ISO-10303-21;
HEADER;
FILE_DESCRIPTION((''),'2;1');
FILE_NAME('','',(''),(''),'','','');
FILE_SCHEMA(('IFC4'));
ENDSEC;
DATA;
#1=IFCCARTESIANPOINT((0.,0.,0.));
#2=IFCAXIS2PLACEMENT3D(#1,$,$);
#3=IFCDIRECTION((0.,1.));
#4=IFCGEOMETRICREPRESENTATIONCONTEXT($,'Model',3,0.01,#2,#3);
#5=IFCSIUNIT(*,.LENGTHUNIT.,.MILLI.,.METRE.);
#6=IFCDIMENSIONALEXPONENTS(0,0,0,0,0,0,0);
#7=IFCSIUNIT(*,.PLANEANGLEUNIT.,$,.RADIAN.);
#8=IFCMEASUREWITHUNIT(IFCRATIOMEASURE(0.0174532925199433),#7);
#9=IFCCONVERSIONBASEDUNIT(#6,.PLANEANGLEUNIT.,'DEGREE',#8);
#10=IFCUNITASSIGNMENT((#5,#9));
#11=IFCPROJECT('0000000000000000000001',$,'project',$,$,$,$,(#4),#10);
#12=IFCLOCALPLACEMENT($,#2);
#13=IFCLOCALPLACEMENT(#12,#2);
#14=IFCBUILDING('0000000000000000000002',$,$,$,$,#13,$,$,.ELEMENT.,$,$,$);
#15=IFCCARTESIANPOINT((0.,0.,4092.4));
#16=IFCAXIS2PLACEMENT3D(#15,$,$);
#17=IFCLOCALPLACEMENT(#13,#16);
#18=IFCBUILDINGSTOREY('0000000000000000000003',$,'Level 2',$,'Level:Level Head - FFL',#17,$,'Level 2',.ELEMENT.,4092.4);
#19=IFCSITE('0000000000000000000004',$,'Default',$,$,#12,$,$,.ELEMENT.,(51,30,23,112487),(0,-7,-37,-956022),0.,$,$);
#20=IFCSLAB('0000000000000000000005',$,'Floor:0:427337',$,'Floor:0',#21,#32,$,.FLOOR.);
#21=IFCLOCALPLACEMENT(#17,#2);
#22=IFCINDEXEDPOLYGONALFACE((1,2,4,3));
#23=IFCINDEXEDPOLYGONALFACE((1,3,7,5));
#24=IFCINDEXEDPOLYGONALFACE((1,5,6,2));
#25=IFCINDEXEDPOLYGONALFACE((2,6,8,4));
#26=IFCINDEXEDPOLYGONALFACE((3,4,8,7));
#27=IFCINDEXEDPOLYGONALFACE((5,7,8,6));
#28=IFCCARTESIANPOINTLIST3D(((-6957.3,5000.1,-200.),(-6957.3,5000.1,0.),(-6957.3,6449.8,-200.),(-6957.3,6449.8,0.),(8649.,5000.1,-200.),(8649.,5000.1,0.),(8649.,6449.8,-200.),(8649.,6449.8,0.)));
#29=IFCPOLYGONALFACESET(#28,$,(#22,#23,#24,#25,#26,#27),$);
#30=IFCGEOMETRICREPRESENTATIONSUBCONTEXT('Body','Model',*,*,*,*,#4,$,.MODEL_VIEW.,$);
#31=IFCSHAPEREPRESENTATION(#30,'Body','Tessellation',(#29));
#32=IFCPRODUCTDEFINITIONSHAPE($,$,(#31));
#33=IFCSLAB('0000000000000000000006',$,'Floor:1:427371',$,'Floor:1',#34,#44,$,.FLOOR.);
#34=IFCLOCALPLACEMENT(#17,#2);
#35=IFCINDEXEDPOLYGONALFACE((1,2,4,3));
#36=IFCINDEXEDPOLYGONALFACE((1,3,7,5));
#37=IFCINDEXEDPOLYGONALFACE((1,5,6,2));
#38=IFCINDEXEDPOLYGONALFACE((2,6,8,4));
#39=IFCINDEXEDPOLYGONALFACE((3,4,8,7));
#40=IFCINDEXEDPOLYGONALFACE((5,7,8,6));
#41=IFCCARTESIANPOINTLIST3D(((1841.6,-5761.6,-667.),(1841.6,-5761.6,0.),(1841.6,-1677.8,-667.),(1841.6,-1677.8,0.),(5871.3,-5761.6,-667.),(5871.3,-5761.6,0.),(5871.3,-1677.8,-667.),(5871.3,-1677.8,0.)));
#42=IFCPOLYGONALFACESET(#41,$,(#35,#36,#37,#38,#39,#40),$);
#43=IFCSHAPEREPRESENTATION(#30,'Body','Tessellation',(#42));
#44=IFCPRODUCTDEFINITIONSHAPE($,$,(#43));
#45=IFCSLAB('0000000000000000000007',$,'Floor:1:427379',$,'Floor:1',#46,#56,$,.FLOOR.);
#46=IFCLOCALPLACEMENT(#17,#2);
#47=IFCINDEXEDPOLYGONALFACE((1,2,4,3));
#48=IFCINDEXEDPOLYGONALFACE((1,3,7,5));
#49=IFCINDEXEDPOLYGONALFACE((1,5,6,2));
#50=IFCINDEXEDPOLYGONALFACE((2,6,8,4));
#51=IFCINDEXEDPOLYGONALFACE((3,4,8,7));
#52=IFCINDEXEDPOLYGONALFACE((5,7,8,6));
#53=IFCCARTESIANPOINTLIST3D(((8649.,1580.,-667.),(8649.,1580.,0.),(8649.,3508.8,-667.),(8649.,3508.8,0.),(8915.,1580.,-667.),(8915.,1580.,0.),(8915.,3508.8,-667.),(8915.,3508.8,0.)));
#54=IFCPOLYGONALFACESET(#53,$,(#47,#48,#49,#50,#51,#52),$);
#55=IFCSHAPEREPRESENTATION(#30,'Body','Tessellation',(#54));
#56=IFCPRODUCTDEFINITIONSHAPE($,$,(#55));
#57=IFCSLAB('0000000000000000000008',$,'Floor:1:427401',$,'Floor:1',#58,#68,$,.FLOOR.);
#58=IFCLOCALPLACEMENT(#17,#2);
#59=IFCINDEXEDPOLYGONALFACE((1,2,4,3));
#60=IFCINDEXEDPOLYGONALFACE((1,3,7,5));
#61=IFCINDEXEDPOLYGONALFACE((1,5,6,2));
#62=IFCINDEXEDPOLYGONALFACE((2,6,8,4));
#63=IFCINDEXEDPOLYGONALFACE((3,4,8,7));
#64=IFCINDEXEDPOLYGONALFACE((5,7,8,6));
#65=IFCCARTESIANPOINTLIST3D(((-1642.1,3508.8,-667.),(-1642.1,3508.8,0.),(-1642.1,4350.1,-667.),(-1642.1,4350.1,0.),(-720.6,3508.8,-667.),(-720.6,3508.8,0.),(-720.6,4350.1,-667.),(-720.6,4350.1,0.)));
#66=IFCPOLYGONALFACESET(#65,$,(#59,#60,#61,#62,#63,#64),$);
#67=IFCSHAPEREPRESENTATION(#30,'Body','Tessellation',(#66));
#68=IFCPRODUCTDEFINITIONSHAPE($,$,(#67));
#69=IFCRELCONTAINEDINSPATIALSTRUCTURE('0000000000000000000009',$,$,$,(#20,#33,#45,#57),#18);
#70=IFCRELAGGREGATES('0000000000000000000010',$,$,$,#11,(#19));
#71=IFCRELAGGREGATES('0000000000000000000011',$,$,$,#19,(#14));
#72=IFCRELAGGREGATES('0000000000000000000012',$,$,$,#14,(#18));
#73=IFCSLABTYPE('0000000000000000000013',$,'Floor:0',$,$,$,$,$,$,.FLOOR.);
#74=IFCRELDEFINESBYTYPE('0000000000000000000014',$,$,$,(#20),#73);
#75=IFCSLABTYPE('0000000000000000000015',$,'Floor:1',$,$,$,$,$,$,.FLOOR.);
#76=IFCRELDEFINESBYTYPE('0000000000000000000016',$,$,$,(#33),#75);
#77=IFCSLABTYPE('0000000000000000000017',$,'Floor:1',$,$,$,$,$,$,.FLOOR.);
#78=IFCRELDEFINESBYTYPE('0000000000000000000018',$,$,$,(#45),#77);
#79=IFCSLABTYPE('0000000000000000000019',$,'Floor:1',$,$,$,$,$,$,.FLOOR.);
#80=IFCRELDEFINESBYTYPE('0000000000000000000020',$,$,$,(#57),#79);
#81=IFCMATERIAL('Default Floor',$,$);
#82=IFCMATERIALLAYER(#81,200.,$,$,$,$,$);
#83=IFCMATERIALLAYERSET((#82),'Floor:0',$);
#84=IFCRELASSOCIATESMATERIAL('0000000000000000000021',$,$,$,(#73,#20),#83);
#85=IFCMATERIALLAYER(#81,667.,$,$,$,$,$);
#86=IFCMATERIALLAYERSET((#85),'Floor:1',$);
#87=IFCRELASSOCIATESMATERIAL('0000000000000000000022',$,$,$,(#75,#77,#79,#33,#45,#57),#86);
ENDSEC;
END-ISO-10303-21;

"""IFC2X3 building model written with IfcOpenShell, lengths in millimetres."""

from ifc_helpers import new_model, entity, si_unit, converted_unit, direction, frame, frame_2d, origin, origin_2d_with_axis, place, context, subcontext, project, spatial, rectangle, extrude, material, layer, layer_set, layer_usage, type_object, element, save


model = new_model("IFC2X3")

# Units and contexts
model_context = context("Model", 3, precision=0.01, world=origin(), true_north=direction((0.0, 1.0)))
body_context = subcontext(model_context, "Body", "Model", "MODEL_VIEW")
ifc_project = project(units=[si_unit("LENGTHUNIT", "METRE", prefix="MILLI"), converted_unit("PLANEANGLEUNIT", "DEGREE", entity("IfcRatioMeasure", 0.0174532925199433), si_unit("PLANEANGLEUNIT", "RADIAN"), dimensions=[0, 0, 0, 0, 0, 0, 0])], contexts=[model_context])

# Site, building, storey
site_placement = place(None, origin())
site = spatial("IfcSite", under=ifc_project, at=site_placement, Name="Default", CompositionType="ELEMENT", RefLatitude=(51, 30, 23, 112487), RefLongitude=(0, -7, -37, -956022), RefElevation=0.0)
building_placement = place(site_placement, origin())
building = spatial("IfcBuilding", under=site, at=building_placement, CompositionType="ELEMENT")
storey_placement = place(building_placement, frame((0.0, 0.0, 4092.4)))
storey = spatial("IfcBuildingStorey", under=building, at=storey_placement, Name="Level 2", ObjectType="Level:Level Head - FFL", LongName="Level 2", CompositionType="ELEMENT", Elevation=4092.4)

# Slabs
ifc_material = material(Name="Default Floor")
ifc_layer_1 = layer(ifc_material, 200.0)
ifc_layer_set_1 = layer_set([ifc_layer_1], Name="Floor:0")
ifc_layer_usage_1 = layer_usage(ifc_layer_set_1, "AXIS3", "POSITIVE", 0.0)
slab_type_1 = type_object("IfcSlabType", Name="Floor:0", PredefinedType="FLOOR", material=ifc_layer_set_1)
slab_1_placement = place(storey_placement, origin())
element("IfcSlab", 1, at=slab_1_placement, inside=storey, type_object=slab_type_1, material=ifc_layer_usage_1, Name="Floor:0:427337", ObjectType="Floor:0", PredefinedType="FLOOR", context=body_context, shape_type="SweptSolid", body=[
    extrude(rectangle(XDim=1449.7, YDim=15606.3, at=frame_2d((0.0, 0.0), x_axis=(1.0, 0.0))), frame((845.8, 5725.0, 0.0), z_axis=(0.0, 0.0, -1.0), x_axis=(0.0, 1.0, 0.0)), (0.0, 0.0, 1.0), 200.0),
])
ifc_layer_2 = layer(ifc_material, 667.0)
ifc_layer_set_2 = layer_set([ifc_layer_2], Name="Floor:1")
ifc_layer_usage_2 = layer_usage(ifc_layer_set_2, "AXIS3", "POSITIVE", 0.0)
slab_type_2 = type_object("IfcSlabType", Name="Floor:1", PredefinedType="FLOOR", material=ifc_layer_set_2)
slab_2_placement = place(storey_placement, origin())
element("IfcSlab", 2, at=slab_2_placement, inside=storey, type_object=slab_type_2, material=ifc_layer_usage_2, Name="Floor:1:427371", ObjectType="Floor:1", PredefinedType="FLOOR", context=body_context, shape_type="SweptSolid", body=[
    extrude(rectangle(XDim=4083.8, YDim=4029.7, at=origin_2d_with_axis()), frame((3856.4, -3719.7, 0.0), z_axis=(0.0, 0.0, -1.0), x_axis=(0.0, 1.0, 0.0)), (0.0, 0.0, 1.0), 667.0),
])
ifc_layer_usage_3 = layer_usage(ifc_layer_set_2, "AXIS3", "POSITIVE", 0.0)
slab_type_3 = type_object("IfcSlabType", Name="Floor:1", PredefinedType="FLOOR", material=ifc_layer_set_2)
slab_3_placement = place(storey_placement, origin())
element("IfcSlab", 3, at=slab_3_placement, inside=storey, type_object=slab_type_3, material=ifc_layer_usage_3, Name="Floor:1:427379", ObjectType="Floor:1", PredefinedType="FLOOR", context=body_context, shape_type="SweptSolid", body=[
    extrude(rectangle(XDim=1928.7, YDim=266.0, at=frame_2d((0.0, 0.0), x_axis=(1.0, 0.0))), frame((8782.0, 2544.4, 0.0), z_axis=(0.0, 0.0, -1.0), x_axis=(0.0, 1.0, 0.0)), (0.0, 0.0, 1.0), 667.0),
])
ifc_layer_usage_4 = layer_usage(ifc_layer_set_2, "AXIS3", "POSITIVE", 0.0)
slab_type_4 = type_object("IfcSlabType", Name="Floor:1", PredefinedType="FLOOR", material=ifc_layer_set_2)
slab_4_placement = place(storey_placement, origin())
element("IfcSlab", 4, at=slab_4_placement, inside=storey, type_object=slab_type_4, material=ifc_layer_usage_4, Name="Floor:1:427401", ObjectType="Floor:1", PredefinedType="FLOOR", context=body_context, shape_type="SweptSolid", body=[
    extrude(rectangle(XDim=841.3, YDim=921.5, at=frame_2d((0.0, 0.0), x_axis=(1.0, 0.0))), frame((-1181.4, 3929.4, 0.0), z_axis=(0.0, 0.0, -1.0), x_axis=(0.0, 1.0, 0.0)), (0.0, 0.0, 1.0), 667.0),
])

save(model, "model.ifc")
